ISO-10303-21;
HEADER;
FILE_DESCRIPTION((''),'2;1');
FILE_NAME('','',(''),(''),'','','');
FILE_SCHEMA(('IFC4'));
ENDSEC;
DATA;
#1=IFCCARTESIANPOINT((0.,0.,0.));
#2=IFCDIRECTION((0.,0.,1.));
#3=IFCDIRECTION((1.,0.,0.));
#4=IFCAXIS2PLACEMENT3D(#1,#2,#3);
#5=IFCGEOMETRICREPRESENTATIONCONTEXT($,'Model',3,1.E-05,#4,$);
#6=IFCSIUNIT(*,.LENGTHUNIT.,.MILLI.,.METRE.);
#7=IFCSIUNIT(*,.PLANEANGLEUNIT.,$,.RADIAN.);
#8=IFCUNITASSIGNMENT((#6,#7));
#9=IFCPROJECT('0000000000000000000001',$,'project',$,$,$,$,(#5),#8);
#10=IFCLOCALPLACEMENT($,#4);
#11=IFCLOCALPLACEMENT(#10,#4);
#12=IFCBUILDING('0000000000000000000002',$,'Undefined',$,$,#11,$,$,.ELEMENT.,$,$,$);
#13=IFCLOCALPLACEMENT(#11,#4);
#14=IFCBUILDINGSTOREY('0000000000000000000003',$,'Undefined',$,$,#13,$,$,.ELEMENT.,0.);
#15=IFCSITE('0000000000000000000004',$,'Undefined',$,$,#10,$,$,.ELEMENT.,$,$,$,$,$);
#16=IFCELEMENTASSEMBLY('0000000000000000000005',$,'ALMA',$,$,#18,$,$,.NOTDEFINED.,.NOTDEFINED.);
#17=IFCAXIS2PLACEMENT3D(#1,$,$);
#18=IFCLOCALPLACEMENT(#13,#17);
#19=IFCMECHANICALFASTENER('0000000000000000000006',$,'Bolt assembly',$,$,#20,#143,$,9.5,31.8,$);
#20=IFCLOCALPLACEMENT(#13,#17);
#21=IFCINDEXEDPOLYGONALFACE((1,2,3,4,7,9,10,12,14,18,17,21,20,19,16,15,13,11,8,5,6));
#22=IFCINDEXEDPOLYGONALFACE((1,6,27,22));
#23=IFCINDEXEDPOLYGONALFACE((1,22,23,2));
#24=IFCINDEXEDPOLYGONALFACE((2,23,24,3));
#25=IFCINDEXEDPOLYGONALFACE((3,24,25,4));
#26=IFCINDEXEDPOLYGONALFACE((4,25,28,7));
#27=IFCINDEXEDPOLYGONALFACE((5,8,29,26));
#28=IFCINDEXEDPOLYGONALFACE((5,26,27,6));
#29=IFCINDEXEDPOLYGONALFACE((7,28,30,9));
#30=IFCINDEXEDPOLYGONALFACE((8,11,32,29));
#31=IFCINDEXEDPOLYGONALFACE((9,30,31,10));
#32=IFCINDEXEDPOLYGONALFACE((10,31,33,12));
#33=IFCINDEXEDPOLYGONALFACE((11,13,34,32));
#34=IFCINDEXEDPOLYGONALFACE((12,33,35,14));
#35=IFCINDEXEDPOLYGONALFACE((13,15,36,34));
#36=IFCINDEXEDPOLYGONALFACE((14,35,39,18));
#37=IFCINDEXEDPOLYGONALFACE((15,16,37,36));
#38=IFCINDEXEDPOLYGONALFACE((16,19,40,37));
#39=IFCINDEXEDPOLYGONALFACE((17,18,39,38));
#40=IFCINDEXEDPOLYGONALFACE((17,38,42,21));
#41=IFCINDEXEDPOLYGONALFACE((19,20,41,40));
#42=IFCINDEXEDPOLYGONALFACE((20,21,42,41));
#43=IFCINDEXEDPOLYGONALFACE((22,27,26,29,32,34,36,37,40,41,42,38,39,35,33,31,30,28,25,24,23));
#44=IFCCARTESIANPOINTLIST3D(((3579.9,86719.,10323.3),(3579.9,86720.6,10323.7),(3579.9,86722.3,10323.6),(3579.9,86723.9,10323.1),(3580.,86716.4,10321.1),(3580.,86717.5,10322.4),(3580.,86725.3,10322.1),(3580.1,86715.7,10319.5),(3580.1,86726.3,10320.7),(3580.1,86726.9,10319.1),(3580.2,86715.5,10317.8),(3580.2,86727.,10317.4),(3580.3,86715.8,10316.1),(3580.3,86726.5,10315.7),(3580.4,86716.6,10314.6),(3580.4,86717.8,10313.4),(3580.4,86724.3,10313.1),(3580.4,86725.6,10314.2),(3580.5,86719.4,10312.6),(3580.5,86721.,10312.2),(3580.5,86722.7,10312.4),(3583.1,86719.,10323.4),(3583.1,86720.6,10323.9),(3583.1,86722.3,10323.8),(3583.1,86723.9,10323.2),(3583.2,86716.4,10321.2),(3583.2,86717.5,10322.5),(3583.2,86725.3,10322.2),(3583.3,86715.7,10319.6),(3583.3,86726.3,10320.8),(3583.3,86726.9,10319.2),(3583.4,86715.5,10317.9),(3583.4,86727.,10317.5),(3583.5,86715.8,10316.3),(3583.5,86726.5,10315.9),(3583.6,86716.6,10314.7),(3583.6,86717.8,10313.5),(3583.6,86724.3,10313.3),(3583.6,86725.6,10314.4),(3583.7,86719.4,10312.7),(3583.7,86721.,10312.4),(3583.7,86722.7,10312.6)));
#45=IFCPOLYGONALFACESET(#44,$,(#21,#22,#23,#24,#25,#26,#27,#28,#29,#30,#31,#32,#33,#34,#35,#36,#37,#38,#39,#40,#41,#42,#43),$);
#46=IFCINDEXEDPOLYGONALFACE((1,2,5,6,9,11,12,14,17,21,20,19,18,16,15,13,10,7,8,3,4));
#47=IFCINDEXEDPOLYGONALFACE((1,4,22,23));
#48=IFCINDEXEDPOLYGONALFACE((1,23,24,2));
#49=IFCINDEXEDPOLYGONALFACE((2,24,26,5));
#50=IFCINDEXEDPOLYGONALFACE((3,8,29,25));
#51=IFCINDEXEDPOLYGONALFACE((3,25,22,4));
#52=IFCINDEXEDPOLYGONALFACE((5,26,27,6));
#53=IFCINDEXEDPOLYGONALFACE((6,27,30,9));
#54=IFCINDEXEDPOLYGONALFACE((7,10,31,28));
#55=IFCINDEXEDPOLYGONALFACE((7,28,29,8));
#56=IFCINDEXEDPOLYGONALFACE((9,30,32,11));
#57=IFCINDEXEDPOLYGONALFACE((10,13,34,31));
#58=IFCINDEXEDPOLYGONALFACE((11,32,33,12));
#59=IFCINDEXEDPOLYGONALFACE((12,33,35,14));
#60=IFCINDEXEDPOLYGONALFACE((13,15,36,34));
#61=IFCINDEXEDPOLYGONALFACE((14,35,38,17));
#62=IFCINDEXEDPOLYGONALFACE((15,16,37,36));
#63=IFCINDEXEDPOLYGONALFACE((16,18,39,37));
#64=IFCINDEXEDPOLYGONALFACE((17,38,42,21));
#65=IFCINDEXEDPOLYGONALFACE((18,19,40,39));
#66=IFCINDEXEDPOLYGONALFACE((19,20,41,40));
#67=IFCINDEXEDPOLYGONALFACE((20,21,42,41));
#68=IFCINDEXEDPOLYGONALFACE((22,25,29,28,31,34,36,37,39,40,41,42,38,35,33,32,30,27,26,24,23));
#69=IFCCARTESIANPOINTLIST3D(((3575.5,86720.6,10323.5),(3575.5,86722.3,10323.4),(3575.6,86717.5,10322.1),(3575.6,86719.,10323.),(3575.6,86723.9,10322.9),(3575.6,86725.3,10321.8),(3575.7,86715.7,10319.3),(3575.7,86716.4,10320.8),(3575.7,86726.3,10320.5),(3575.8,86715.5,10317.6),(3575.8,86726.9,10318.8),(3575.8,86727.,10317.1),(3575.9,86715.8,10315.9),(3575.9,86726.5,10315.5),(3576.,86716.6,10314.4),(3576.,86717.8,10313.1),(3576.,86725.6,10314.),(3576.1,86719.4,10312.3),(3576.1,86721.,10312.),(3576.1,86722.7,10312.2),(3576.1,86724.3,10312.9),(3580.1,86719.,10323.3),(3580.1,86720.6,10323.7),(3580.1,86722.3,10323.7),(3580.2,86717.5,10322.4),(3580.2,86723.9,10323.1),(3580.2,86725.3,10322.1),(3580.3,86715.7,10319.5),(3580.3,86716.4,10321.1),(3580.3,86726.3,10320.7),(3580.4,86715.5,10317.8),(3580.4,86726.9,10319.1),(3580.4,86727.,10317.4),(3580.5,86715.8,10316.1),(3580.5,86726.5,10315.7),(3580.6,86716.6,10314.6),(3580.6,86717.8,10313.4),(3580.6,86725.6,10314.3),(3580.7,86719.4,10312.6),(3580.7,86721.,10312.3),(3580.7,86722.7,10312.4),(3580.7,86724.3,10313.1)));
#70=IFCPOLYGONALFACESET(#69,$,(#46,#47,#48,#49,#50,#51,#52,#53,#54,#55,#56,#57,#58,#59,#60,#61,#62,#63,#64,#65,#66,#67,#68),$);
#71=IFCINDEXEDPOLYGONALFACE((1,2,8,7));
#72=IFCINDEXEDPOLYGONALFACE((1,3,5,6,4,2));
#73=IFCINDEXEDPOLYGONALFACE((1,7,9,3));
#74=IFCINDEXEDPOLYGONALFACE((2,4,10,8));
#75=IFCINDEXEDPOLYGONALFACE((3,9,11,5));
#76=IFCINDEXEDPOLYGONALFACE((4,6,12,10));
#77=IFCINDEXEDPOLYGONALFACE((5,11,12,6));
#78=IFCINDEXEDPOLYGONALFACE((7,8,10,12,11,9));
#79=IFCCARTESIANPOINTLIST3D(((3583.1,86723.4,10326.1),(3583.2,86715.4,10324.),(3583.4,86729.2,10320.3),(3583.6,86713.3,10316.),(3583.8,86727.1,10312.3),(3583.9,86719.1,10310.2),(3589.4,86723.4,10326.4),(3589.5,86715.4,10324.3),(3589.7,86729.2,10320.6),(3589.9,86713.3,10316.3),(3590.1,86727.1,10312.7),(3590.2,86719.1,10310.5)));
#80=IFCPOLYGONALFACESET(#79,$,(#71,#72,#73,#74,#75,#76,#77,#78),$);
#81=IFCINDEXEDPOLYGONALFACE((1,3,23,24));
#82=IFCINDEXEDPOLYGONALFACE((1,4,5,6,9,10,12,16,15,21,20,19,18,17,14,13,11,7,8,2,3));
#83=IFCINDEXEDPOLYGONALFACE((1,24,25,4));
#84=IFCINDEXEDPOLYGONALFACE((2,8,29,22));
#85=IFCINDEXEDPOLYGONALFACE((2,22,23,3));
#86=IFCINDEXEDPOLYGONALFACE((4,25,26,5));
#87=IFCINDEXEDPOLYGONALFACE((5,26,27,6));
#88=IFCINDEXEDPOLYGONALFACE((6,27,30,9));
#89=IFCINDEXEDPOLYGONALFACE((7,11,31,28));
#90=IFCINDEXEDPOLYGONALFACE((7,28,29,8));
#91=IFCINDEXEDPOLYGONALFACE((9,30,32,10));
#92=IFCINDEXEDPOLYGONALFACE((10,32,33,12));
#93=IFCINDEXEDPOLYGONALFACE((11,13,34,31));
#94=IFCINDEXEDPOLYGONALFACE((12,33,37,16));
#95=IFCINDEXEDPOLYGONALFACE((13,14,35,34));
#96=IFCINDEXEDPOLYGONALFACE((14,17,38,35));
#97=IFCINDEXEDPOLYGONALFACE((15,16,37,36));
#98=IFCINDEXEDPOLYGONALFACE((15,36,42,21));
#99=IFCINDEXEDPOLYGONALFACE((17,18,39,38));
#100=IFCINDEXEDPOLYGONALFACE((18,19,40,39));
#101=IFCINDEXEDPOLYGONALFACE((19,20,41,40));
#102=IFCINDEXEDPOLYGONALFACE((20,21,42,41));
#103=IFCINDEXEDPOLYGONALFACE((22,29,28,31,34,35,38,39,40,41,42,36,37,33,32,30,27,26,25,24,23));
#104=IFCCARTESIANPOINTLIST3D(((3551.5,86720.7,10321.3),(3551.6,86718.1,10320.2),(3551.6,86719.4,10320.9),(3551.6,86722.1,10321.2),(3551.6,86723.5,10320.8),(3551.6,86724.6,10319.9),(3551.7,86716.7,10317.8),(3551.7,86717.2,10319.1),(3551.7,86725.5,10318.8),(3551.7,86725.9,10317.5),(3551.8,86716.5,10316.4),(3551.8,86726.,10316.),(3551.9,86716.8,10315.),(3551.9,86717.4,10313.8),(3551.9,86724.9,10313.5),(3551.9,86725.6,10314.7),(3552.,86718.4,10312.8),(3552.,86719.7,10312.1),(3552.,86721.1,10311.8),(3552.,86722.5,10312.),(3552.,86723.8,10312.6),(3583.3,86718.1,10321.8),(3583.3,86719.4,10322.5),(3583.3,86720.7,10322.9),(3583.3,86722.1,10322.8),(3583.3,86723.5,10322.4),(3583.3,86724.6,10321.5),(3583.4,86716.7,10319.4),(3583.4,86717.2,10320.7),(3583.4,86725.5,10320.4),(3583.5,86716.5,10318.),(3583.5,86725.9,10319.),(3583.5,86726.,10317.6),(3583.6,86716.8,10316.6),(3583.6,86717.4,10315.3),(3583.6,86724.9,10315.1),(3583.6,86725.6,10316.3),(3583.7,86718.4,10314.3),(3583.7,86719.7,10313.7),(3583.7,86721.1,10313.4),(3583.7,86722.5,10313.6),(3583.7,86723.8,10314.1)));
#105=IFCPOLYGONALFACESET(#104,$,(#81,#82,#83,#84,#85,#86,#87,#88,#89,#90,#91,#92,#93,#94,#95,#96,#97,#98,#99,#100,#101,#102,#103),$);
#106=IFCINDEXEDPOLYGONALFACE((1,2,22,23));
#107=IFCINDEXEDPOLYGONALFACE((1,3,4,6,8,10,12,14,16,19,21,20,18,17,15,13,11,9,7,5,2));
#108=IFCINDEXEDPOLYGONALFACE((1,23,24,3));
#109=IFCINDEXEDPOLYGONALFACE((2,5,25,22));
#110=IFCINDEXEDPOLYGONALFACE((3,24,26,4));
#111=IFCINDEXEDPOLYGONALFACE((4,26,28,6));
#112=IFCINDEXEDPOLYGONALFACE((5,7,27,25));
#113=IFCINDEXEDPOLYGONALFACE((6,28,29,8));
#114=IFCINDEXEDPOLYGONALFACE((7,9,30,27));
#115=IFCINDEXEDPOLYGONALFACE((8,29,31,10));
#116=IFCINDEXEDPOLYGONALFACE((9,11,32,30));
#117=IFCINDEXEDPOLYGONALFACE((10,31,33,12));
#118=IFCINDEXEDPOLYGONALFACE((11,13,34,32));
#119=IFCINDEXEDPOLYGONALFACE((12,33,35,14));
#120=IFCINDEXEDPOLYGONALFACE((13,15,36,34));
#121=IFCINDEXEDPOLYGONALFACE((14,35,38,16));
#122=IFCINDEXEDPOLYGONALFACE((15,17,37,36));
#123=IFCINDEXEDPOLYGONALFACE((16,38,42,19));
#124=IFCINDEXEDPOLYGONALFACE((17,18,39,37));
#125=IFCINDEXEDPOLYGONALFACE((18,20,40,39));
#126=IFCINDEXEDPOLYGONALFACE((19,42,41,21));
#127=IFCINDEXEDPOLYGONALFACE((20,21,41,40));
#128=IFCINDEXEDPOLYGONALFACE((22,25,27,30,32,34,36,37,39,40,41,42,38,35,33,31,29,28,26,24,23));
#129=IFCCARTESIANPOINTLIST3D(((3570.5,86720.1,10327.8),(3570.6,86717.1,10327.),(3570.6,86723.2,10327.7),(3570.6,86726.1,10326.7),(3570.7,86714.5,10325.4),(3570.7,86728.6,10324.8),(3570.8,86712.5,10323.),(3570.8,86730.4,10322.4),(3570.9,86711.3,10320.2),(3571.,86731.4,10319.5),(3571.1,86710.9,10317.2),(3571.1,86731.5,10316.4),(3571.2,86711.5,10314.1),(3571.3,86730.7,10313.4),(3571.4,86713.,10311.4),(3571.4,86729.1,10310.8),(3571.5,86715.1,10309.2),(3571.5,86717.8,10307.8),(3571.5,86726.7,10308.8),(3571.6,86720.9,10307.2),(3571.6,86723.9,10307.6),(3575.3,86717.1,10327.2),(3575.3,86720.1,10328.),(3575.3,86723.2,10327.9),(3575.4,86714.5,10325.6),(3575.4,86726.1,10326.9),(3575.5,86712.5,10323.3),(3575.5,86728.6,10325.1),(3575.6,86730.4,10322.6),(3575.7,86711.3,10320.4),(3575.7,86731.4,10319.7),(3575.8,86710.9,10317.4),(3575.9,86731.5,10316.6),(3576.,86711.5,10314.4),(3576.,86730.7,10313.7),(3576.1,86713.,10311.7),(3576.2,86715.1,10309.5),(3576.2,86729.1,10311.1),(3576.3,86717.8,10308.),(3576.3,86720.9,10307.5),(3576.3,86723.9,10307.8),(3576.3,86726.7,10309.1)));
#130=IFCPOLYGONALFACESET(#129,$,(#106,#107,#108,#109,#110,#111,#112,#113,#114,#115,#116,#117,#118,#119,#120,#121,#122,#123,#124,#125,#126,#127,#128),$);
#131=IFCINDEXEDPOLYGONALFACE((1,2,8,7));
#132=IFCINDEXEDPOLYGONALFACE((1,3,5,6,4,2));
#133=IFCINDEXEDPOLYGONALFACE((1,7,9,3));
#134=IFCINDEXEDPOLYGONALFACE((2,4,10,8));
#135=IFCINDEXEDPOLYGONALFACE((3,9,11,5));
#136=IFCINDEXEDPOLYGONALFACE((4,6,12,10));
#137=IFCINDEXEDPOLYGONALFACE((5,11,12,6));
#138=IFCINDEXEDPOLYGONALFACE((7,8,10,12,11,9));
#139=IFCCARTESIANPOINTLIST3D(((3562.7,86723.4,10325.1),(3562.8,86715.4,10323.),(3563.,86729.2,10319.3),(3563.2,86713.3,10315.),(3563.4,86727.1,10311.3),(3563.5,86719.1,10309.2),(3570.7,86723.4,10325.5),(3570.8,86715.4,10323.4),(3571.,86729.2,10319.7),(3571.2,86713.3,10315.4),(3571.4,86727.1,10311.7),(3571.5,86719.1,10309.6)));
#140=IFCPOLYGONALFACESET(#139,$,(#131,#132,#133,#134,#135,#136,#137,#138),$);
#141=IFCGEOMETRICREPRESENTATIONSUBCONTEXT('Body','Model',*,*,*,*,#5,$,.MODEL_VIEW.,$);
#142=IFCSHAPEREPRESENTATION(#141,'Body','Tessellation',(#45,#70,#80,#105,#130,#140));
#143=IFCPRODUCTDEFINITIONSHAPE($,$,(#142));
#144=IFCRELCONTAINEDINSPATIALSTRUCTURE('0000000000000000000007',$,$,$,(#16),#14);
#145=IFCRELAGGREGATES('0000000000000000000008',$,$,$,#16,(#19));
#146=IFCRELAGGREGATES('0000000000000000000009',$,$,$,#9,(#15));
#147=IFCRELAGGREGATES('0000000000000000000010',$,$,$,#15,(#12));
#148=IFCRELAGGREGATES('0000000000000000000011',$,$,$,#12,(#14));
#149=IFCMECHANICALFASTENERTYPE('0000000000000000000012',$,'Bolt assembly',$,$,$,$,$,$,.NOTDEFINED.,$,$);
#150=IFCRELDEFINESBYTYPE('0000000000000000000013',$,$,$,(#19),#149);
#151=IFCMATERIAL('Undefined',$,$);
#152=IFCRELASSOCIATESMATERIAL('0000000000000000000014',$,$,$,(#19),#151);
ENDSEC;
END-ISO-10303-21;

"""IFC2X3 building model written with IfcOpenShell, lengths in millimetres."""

from ifc_helpers import new_model, si_unit, frame, origin_with_axes, origin_2d_with_axis, place, context, subcontext, project, spatial, polyline, circle, outline, extrude, source, transform, mapped, material, type_object, element, aggregate, save


model = new_model("IFC2X3")

# Units and contexts
model_context = context("Model", 3, precision=1e-05, world=origin_with_axes())
body_context = subcontext(model_context, "Body", "Model", "MODEL_VIEW")
ifc_project = project(units=[si_unit("LENGTHUNIT", "METRE", prefix="MILLI"), si_unit("PLANEANGLEUNIT", "RADIAN")], contexts=[model_context])

# Site, building, storey
site_placement = place(None, origin_with_axes())
site = spatial("IfcSite", under=ifc_project, at=site_placement, Name="Undefined", CompositionType="ELEMENT")
building_placement = place(site_placement, origin_with_axes())
building = spatial("IfcBuilding", under=site, at=building_placement, Name="Undefined", CompositionType="ELEMENT")
storey_placement = place(building_placement, origin_with_axes())
storey = spatial("IfcBuildingStorey", under=building, at=storey_placement, Name="Undefined", CompositionType="ELEMENT", Elevation=0.0)

# Element assembly
assembly_1_placement = place(storey_placement, origin_with_axes())
assembly_1 = element("IfcElementAssembly", 1, at=assembly_1_placement, inside=storey, Name="ALMA", AssemblyPlace="NOTDEFINED", PredefinedType="NOTDEFINED")

# Shared definitions
ifc_material_1 = material(Name="Undefined")
mechanical_fastener_type = type_object("IfcMechanicalFastenerType", Name="Bolt assembly")

# Mechanical fastener
shared_shape_1 = source(origin_with_axes(), body_context, "Body", "SweptSolid", [
    extrude(circle(Radius=5.8, at=origin_2d_with_axis()), frame((0.0, -7.6, 0.0), z_axis=(0.0, 1.0, 0.0), x_axis=(1.0, 0.0, 0.0)), (0.0, 0.0, 1.0), 3.2),
    extrude(circle(Radius=5.8, at=origin_2d_with_axis()), frame((0.0, -4.6, 0.0), z_axis=(0.0, 1.0, 0.0), x_axis=(1.0, 0.0, 0.0)), (0.0, 0.0, 1.0), 4.6),
    extrude(outline(polyline([(7.1, -4.1), (7.1, 4.1), (0.0, 8.2), (-7.1, 4.1), (-7.1, -4.1), (0.0, -8.2), (7.1, -4.1)])), frame((0.0, -14.0, 0.0), z_axis=(0.0, 1.0, 0.0), x_axis=(1.0, 0.0, 0.0)), (0.0, 0.0, 1.0), 6.3),
    extrude(circle(Radius=4.8, at=origin_2d_with_axis()), frame((0.0, -7.7, 0.0), z_axis=(0.0, 1.0, 0.0), x_axis=(1.0, 0.0, 0.0)), (0.0, 0.0, 1.0), 31.8),
    extrude(circle(Radius=10.3, at=origin_2d_with_axis()), frame((0.0, 0.0, 0.0), z_axis=(0.0, 1.0, 0.0), x_axis=(1.0, 0.0, 0.0)), (0.0, 0.0, 1.0), 4.8),
    extrude(outline(polyline([(7.1, -4.1), (7.1, 4.1), (0.0, 8.2), (-7.1, 4.1), (-7.1, -4.1), (0.0, -8.2), (7.1, -4.1)])), frame((0.0, 4.8, 0.0), z_axis=(0.0, 1.0, 0.0), x_axis=(1.0, 0.0, 0.0)), (0.0, 0.0, 1.0), 7.9),
])
mechanical_fastener_1_placement = place(assembly_1_placement, frame((3575.8, 86721.3, 10317.8), z_axis=(-0.035282, -0.707107, 0.706226), x_axis=(-0.035281, 0.707107, 0.706226)))
mechanical_fastener_1 = element("IfcMechanicalFastener", 2, at=mechanical_fastener_1_placement, type_object=mechanical_fastener_type, material=ifc_material_1, Name="Bolt assembly", NominalDiameter=9.5, NominalLength=31.8, context=body_context, shape_type="MappedRepresentation", body=[
    mapped(shared_shape_1, transform((0.0, 0.0, 0.0))),
])

aggregate(assembly_1, [mechanical_fastener_1])

save(model, "model.ifc")
